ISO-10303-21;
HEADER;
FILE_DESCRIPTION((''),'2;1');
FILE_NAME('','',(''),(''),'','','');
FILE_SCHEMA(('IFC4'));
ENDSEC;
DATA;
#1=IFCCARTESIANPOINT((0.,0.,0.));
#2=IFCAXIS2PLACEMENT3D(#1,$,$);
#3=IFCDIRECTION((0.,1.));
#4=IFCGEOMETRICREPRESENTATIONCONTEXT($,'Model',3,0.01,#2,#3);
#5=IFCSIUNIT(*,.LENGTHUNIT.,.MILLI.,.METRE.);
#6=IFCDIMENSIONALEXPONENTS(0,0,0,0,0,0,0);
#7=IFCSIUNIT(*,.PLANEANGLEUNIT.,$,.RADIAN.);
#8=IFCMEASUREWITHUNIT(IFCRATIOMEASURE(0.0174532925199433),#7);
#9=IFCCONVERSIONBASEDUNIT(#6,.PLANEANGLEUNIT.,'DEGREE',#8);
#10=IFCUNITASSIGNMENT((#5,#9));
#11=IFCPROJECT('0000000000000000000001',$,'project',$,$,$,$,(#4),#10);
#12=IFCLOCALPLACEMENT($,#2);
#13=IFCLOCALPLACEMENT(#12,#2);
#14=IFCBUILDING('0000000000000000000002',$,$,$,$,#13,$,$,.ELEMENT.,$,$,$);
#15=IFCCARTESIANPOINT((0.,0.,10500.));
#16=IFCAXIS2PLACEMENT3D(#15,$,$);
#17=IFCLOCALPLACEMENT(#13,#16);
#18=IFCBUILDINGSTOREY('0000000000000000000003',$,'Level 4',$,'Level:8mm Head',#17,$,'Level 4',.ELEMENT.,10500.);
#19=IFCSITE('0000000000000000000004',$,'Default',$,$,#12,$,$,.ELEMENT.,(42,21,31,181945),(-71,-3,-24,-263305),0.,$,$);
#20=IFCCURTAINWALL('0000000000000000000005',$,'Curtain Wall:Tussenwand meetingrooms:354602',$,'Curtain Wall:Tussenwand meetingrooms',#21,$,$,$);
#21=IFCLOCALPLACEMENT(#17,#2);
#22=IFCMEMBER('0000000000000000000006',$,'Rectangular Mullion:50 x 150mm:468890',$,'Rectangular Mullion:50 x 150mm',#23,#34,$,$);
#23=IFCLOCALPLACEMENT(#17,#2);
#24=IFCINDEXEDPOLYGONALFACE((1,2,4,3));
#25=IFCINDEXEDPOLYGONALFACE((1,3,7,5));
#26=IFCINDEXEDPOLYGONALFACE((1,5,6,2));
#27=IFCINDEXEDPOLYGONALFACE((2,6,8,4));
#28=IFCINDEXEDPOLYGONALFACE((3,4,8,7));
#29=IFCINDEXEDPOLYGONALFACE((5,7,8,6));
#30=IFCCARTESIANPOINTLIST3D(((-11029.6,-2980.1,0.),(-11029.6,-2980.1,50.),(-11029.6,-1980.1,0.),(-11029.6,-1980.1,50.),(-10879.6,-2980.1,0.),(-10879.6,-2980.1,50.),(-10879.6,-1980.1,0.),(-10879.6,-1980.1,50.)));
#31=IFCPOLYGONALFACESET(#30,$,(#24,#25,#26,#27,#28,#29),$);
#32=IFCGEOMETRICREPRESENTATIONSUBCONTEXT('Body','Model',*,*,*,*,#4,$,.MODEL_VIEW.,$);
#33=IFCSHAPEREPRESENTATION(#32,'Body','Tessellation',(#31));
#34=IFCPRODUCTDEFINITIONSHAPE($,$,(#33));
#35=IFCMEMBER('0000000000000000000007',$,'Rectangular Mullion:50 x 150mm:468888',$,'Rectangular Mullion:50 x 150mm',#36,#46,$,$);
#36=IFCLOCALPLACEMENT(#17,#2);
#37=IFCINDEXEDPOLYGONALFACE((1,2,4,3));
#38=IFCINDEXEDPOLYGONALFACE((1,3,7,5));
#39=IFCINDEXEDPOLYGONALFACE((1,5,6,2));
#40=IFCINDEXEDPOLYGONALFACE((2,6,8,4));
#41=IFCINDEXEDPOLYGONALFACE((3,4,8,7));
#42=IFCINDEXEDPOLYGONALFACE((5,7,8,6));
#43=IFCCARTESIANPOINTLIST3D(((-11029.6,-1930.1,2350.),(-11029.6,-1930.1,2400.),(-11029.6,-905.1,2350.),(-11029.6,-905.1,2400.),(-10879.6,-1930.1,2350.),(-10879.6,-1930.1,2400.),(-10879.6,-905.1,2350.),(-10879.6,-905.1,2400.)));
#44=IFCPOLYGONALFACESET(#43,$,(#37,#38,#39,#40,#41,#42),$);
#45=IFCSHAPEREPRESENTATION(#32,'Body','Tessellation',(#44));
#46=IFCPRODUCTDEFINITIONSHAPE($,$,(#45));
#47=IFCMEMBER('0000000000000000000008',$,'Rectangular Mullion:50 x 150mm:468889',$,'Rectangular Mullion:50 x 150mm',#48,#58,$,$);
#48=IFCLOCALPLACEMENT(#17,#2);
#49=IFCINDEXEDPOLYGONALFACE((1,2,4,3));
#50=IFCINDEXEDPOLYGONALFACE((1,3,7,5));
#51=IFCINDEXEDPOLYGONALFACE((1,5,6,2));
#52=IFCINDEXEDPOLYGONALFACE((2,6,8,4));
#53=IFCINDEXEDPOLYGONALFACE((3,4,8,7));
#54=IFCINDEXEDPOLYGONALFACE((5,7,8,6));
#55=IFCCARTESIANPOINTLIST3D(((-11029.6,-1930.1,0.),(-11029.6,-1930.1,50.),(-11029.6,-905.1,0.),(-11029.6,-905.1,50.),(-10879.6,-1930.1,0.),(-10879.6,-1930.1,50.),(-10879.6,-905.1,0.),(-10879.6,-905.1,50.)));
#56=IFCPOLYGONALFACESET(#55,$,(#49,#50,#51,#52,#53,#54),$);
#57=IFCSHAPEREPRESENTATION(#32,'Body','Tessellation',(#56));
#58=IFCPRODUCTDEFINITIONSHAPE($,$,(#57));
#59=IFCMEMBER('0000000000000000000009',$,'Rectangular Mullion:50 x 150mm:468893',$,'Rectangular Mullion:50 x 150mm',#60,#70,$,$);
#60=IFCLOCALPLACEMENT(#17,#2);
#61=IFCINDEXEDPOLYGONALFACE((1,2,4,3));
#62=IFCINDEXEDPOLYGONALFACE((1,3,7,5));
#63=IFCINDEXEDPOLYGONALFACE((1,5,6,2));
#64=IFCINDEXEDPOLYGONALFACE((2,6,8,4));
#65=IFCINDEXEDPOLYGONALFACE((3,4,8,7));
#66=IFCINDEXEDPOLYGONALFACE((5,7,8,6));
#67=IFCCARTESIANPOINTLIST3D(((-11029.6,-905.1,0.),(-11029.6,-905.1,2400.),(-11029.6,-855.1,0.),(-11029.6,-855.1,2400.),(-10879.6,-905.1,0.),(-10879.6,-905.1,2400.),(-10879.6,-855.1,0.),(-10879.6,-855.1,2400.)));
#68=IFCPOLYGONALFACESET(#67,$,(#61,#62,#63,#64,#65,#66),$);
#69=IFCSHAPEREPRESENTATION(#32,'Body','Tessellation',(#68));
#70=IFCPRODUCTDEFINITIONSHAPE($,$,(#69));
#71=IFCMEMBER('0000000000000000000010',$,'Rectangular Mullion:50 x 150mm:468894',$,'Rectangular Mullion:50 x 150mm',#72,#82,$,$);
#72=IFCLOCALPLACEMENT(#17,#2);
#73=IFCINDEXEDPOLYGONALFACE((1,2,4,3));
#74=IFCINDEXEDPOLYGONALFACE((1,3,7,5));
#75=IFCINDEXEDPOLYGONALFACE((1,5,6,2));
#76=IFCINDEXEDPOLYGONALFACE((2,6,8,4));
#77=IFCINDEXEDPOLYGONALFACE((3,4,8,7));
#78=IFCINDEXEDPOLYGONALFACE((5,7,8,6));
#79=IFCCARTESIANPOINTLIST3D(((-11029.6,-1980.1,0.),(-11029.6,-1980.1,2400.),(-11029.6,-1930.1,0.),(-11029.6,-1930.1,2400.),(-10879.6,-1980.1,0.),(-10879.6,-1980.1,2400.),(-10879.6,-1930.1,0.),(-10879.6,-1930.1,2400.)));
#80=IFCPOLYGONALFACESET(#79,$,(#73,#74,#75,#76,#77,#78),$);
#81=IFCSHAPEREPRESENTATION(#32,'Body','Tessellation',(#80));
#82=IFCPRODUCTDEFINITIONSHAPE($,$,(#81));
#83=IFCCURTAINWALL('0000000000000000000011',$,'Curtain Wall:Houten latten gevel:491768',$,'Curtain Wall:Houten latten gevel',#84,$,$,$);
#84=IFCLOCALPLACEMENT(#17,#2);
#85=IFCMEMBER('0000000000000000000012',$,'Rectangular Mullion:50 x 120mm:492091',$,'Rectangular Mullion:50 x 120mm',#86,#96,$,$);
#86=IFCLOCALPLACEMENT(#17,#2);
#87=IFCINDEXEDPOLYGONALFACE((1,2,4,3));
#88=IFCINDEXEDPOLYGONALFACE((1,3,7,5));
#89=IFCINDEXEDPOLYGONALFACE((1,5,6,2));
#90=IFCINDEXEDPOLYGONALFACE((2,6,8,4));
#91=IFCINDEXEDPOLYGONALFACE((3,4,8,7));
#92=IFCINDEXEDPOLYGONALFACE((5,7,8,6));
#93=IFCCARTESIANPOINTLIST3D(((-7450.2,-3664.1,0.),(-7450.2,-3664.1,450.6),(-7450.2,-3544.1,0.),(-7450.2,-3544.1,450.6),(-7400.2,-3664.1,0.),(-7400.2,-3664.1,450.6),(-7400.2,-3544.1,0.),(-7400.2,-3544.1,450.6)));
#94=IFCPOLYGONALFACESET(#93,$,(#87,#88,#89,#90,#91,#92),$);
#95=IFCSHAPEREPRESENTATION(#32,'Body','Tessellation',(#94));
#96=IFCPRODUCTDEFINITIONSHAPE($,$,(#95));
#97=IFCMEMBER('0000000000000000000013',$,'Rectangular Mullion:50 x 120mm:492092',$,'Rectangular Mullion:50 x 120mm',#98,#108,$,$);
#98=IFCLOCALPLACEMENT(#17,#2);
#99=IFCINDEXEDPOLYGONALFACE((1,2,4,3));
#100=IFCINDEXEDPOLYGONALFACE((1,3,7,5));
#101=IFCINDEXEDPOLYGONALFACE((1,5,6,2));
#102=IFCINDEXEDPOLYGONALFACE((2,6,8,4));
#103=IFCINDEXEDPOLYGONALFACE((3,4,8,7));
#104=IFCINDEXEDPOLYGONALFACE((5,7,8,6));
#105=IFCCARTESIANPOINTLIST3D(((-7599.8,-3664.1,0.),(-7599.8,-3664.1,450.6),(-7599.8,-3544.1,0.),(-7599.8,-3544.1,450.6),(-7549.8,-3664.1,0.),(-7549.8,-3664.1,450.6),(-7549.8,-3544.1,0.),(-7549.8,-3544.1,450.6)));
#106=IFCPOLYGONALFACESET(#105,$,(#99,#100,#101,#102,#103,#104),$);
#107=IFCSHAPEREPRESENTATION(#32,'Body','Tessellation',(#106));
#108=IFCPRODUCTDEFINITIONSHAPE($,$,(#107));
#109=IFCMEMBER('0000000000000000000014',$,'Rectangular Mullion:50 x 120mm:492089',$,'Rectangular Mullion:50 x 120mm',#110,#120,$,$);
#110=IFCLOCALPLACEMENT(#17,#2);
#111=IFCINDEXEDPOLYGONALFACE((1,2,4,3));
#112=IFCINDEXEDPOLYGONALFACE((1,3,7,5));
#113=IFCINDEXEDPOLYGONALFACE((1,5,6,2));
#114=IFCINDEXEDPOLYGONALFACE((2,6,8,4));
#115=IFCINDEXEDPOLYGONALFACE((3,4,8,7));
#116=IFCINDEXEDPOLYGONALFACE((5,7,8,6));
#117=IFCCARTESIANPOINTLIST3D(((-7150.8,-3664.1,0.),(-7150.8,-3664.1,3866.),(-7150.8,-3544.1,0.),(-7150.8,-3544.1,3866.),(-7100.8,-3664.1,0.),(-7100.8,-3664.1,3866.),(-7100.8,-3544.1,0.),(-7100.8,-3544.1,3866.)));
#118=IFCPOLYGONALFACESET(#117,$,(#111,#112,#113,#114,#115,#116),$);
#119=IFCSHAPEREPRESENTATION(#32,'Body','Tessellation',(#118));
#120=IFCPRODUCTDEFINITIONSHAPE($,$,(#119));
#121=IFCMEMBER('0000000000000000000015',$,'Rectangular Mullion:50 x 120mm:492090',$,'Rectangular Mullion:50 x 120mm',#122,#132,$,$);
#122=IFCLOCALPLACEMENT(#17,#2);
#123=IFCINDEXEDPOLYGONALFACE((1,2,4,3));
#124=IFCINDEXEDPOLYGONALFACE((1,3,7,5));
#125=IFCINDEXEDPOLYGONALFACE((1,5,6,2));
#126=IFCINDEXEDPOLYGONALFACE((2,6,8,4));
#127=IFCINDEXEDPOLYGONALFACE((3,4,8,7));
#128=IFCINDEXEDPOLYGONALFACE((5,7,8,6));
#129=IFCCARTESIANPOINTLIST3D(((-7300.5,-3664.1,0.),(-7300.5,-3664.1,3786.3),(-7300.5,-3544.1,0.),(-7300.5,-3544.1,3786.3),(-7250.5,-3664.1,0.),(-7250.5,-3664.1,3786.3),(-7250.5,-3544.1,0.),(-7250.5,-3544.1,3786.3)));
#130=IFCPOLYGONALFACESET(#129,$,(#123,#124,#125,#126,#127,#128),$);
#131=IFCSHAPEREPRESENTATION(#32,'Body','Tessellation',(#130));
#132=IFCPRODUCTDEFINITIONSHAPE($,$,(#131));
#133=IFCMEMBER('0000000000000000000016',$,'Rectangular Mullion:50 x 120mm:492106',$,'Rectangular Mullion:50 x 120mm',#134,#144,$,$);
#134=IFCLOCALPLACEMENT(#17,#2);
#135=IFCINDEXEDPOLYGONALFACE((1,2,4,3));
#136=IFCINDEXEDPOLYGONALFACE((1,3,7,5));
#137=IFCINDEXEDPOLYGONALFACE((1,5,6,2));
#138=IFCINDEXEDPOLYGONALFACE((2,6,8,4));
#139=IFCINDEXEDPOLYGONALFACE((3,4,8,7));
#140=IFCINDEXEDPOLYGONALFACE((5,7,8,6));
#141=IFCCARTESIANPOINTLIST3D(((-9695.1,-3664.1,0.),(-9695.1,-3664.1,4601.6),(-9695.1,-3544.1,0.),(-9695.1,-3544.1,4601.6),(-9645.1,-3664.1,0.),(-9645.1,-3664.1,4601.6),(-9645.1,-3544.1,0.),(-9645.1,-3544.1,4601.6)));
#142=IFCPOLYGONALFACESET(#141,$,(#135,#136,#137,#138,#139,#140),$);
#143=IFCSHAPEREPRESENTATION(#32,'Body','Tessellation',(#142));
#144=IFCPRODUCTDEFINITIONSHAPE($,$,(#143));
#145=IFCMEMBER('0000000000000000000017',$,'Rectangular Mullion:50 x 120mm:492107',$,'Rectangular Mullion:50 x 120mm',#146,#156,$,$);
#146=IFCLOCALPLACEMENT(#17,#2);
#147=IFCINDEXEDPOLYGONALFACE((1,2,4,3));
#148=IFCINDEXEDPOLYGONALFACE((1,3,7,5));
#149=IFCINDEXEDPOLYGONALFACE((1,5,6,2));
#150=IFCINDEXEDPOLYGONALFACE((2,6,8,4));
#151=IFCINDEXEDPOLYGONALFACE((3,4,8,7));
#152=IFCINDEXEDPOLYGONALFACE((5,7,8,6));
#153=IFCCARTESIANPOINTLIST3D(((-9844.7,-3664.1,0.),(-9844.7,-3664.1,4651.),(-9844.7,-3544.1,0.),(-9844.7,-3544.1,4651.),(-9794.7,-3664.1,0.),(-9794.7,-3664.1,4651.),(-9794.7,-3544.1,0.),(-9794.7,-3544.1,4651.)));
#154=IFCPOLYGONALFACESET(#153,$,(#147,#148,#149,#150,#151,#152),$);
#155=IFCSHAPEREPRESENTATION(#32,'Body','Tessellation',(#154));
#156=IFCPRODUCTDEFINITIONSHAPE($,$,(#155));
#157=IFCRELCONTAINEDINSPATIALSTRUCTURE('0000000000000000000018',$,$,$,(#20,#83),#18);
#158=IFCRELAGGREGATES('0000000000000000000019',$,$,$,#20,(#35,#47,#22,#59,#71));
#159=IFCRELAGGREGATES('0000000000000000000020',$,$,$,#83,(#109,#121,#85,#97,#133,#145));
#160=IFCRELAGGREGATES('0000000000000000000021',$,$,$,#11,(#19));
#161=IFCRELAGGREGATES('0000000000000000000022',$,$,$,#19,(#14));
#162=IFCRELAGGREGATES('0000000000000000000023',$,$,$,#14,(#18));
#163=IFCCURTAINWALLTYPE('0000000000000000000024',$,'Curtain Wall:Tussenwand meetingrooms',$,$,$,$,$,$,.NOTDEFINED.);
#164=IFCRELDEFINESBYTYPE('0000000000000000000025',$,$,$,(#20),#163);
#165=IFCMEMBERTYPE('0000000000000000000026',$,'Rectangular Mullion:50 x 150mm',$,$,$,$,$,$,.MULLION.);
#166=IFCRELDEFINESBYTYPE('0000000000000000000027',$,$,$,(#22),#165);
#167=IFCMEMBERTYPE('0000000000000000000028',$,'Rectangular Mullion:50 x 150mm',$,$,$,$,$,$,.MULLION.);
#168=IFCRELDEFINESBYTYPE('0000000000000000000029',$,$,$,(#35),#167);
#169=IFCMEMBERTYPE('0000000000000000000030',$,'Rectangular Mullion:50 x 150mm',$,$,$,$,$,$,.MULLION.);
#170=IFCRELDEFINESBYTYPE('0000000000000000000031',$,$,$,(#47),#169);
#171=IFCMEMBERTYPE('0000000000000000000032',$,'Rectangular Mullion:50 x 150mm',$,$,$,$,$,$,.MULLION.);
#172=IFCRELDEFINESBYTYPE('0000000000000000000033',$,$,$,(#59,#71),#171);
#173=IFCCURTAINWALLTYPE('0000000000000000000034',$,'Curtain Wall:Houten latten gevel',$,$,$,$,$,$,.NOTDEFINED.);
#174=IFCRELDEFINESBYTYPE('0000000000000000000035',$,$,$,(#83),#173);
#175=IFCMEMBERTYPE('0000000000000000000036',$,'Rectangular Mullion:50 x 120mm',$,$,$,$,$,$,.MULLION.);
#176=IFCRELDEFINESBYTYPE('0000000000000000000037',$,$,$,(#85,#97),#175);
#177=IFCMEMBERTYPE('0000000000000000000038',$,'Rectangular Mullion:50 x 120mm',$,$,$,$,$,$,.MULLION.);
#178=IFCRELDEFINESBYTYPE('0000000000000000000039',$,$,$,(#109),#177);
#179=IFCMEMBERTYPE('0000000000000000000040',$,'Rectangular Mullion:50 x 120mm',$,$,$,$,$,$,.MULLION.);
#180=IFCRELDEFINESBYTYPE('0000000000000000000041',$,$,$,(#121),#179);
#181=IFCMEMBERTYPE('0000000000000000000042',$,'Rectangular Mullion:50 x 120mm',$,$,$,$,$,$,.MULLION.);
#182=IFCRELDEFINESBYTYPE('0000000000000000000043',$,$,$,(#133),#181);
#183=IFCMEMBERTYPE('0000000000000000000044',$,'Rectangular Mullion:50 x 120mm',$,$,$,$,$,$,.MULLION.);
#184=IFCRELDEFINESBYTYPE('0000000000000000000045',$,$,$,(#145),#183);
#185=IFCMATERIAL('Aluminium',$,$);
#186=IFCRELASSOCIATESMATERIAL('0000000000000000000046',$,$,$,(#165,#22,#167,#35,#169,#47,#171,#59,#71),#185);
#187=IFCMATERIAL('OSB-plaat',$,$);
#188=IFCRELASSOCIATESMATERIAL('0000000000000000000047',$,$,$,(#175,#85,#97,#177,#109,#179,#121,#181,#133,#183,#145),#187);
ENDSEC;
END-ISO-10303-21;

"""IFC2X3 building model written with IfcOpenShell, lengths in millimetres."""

from ifc_helpers import new_model, entity, si_unit, converted_unit, direction, frame, origin, origin_2d_with_axis, place, context, subcontext, project, spatial, rectangle, extrude, source, transform, mapped, material, type_object, type_shapes, element, aggregate, save


model = new_model("IFC2X3")

# Units and contexts
model_context = context("Model", 3, precision=0.01, world=origin(), true_north=direction((0.0, 1.0)))
body_context = subcontext(model_context, "Body", "Model", "MODEL_VIEW")
ifc_project = project(units=[si_unit("LENGTHUNIT", "METRE", prefix="MILLI"), converted_unit("PLANEANGLEUNIT", "DEGREE", entity("IfcRatioMeasure", 0.0174532925199433), si_unit("PLANEANGLEUNIT", "RADIAN"), dimensions=[0, 0, 0, 0, 0, 0, 0])], contexts=[model_context])

# Site, building, storey
site_placement = place(None, frame((0.0, 0.0, 0.0)))
site = spatial("IfcSite", under=ifc_project, at=site_placement, Name="Default", CompositionType="ELEMENT", RefLatitude=(42, 21, 31, 181945), RefLongitude=(-71, -3, -24, -263305), RefElevation=0.0)
building_placement = place(site_placement, origin())
building = spatial("IfcBuilding", under=site, at=building_placement, CompositionType="ELEMENT")
storey_placement = place(building_placement, frame((0.0, 0.0, 10500.0)))
storey = spatial("IfcBuildingStorey", under=building, at=storey_placement, Name="Level 4", ObjectType="Level:8mm Head", LongName="Level 4", CompositionType="ELEMENT", Elevation=10500.0)

# Curtain walls, members
curtain_wall_type_1 = type_object("IfcCurtainWallType", Name="Curtain Wall:Tussenwand meetingrooms", PredefinedType="NOTDEFINED")
curtain_wall_1_placement = place(storey_placement, frame((0.0, 0.0, -10500.0)))
curtain_wall_1 = element("IfcCurtainWall", 1, at=curtain_wall_1_placement, inside=storey, type_object=curtain_wall_type_1, Name="Curtain Wall:Tussenwand meetingrooms:354602", ObjectType="Curtain Wall:Tussenwand meetingrooms")
ifc_material_1 = material(Name="Aluminium")
member_type_1 = type_object("IfcMemberType", Name="Rectangular Mullion:50 x 150mm", PredefinedType="MULLION", material=ifc_material_1)
shared_shape_1 = source(origin(), body_context, "Body", "SweptSolid", [
    extrude(rectangle(XDim=150.0, YDim=50.0, at=origin_2d_with_axis()), frame((-25.0, 0.0, -1000.0), z_axis=(0.0, 0.0, 1.0), x_axis=(0.0, -1.0, 0.0)), (0.0, 0.0, 1.0), 1000.0),
])
type_shapes(member_type_1, [shared_shape_1])
member_1_placement = place(storey_placement, frame((-10954.6, -1980.1, 0.0), z_axis=(0.0, 1.0, 0.0), x_axis=(0.0, 0.0, -1.0)))
member_1 = element("IfcMember", 2, at=member_1_placement, type_object=member_type_1, material=ifc_material_1, Name="Rectangular Mullion:50 x 150mm:468890", ObjectType="Rectangular Mullion:50 x 150mm", context=body_context, shape_type="MappedRepresentation", body=[
    mapped(shared_shape_1, transform((0.0, 0.0, 0.0), scale=1.0)),
])
member_type_2 = type_object("IfcMemberType", Name="Rectangular Mullion:50 x 150mm", PredefinedType="MULLION", material=ifc_material_1)
shared_shape_2 = source(origin(), body_context, "Body", "SweptSolid", [
    extrude(rectangle(XDim=150.0, YDim=50.0, at=origin_2d_with_axis()), frame((-25.0, 0.0, -1025.0), z_axis=(0.0, 0.0, 1.0), x_axis=(0.0, -1.0, 0.0)), (0.0, 0.0, 1.0), 1025.0),
])
type_shapes(member_type_2, [shared_shape_2])
member_2_placement = place(storey_placement, frame((-10954.6, -1930.1, 2400.0), z_axis=(0.0, -1.0, 0.0), x_axis=(0.0, 0.0, 1.0)))
member_2 = element("IfcMember", 3, at=member_2_placement, type_object=member_type_2, material=ifc_material_1, Name="Rectangular Mullion:50 x 150mm:468888", ObjectType="Rectangular Mullion:50 x 150mm", context=body_context, shape_type="MappedRepresentation", body=[
    mapped(shared_shape_2, transform((0.0, 0.0, 0.0), scale=1.0)),
])
member_type_3 = type_object("IfcMemberType", Name="Rectangular Mullion:50 x 150mm", PredefinedType="MULLION", material=ifc_material_1)
shared_shape_3 = source(origin(), body_context, "Body", "SweptSolid", [
    extrude(rectangle(XDim=150.0, YDim=50.0, at=origin_2d_with_axis()), frame((-25.0, 0.0, -1025.0), z_axis=(0.0, 0.0, 1.0), x_axis=(0.0, -1.0, 0.0)), (0.0, 0.0, 1.0), 1025.0),
])
type_shapes(member_type_3, [shared_shape_3])
member_3_placement = place(storey_placement, frame((-10954.6, -905.1, 0.0), z_axis=(0.0, 1.0, 0.0), x_axis=(0.0, 0.0, -1.0)))
member_3 = element("IfcMember", 4, at=member_3_placement, type_object=member_type_3, material=ifc_material_1, Name="Rectangular Mullion:50 x 150mm:468889", ObjectType="Rectangular Mullion:50 x 150mm", context=body_context, shape_type="MappedRepresentation", body=[
    mapped(shared_shape_3, transform((0.0, 0.0, 0.0), scale=1.0)),
])
member_type_4 = type_object("IfcMemberType", Name="Rectangular Mullion:50 x 150mm", PredefinedType="MULLION", material=ifc_material_1)
shared_shape_4 = source(origin(), body_context, "Body", "SweptSolid", [
    extrude(rectangle(XDim=150.0, YDim=50.0, at=origin_2d_with_axis()), frame((0.0, 0.0, -2400.0), z_axis=(0.0, 0.0, 1.0), x_axis=(0.0, -1.0, 0.0)), (0.0, 0.0, 1.0), 2400.0),
])
type_shapes(member_type_4, [shared_shape_4])
member_4_placement = place(storey_placement, frame((-10954.6, -880.1, 0.0), z_axis=(0.0, 0.0, -1.0), x_axis=(0.0, -1.0, 0.0)))
member_4 = element("IfcMember", 5, at=member_4_placement, type_object=member_type_4, material=ifc_material_1, Name="Rectangular Mullion:50 x 150mm:468893", ObjectType="Rectangular Mullion:50 x 150mm", context=body_context, shape_type="MappedRepresentation", body=[
    mapped(shared_shape_4, transform((0.0, 0.0, 0.0), scale=1.0)),
])
member_5_placement = place(storey_placement, frame((-10954.6, -1955.1, 0.0), z_axis=(0.0, 0.0, -1.0), x_axis=(0.0, -1.0, 0.0)))
member_5 = element("IfcMember", 6, at=member_5_placement, type_object=member_type_4, material=ifc_material_1, Name="Rectangular Mullion:50 x 150mm:468894", ObjectType="Rectangular Mullion:50 x 150mm", context=body_context, shape_type="MappedRepresentation", body=[
    mapped(shared_shape_4, transform((0.0, 0.0, 0.0), scale=1.0)),
])
aggregate(curtain_wall_1, [member_2, member_3, member_1, member_4, member_5])
curtain_wall_type_2 = type_object("IfcCurtainWallType", Name="Curtain Wall:Houten latten gevel", PredefinedType="NOTDEFINED")
curtain_wall_2_placement = place(storey_placement, frame((0.0, 0.0, -10500.0)))
curtain_wall_2 = element("IfcCurtainWall", 7, at=curtain_wall_2_placement, inside=storey, type_object=curtain_wall_type_2, Name="Curtain Wall:Houten latten gevel:491768", ObjectType="Curtain Wall:Houten latten gevel")
ifc_material_2 = material(Name="OSB-plaat")
member_type_5 = type_object("IfcMemberType", Name="Rectangular Mullion:50 x 120mm", PredefinedType="MULLION", material=ifc_material_2)
shared_shape_5 = source(origin(), body_context, "Body", "SweptSolid", [
    extrude(rectangle(XDim=120.0, YDim=50.0, at=origin_2d_with_axis()), frame((0.0, 0.0, -450.6), z_axis=(0.0, 0.0, 1.0), x_axis=(0.0, -1.0, 0.0)), (0.0, 0.0, 1.0), 450.6),
])
type_shapes(member_type_5, [shared_shape_5])
placement = place(building_placement, frame((0.0, 0.0, 7500.0)))
member_6_placement = place(placement, frame((-7425.2, -3604.1, 3000.0), z_axis=(0.0, 0.0, -1.0), x_axis=(-1.0, 0.0, 0.0)))
member_6 = element("IfcMember", 8, at=member_6_placement, type_object=member_type_5, material=ifc_material_2, Name="Rectangular Mullion:50 x 120mm:492091", ObjectType="Rectangular Mullion:50 x 120mm", context=body_context, shape_type="MappedRepresentation", body=[
    mapped(shared_shape_5, transform((0.0, 0.0, 0.0), scale=1.0)),
])
member_7_placement = place(placement, frame((-7574.8, -3604.1, 3000.0), z_axis=(0.0, 0.0, -1.0), x_axis=(-1.0, 0.0, 0.0)))
member_7 = element("IfcMember", 9, at=member_7_placement, type_object=member_type_5, material=ifc_material_2, Name="Rectangular Mullion:50 x 120mm:492092", ObjectType="Rectangular Mullion:50 x 120mm", context=body_context, shape_type="MappedRepresentation", body=[
    mapped(shared_shape_5, transform((0.0, 0.0, 0.0), scale=1.0)),
])
member_type_6 = type_object("IfcMemberType", Name="Rectangular Mullion:50 x 120mm", PredefinedType="MULLION", material=ifc_material_2)
shared_shape_6 = source(origin(), body_context, "Body", "SweptSolid", [
    extrude(rectangle(XDim=120.0, YDim=50.0, at=origin_2d_with_axis()), frame((0.0, 0.0, -3866.0), z_axis=(0.0, 0.0, 1.0), x_axis=(0.0, -1.0, 0.0)), (0.0, 0.0, 1.0), 3866.0),
])
type_shapes(member_type_6, [shared_shape_6])
member_8_placement = place(placement, frame((-7125.8, -3604.1, 3000.0), z_axis=(0.0, 0.0, -1.0), x_axis=(-1.0, 0.0, 0.0)))
member_8 = element("IfcMember", 10, at=member_8_placement, type_object=member_type_6, material=ifc_material_2, Name="Rectangular Mullion:50 x 120mm:492089", ObjectType="Rectangular Mullion:50 x 120mm", context=body_context, shape_type="MappedRepresentation", body=[
    mapped(shared_shape_6, transform((0.0, 0.0, 0.0), scale=1.0)),
])
member_type_7 = type_object("IfcMemberType", Name="Rectangular Mullion:50 x 120mm", PredefinedType="MULLION", material=ifc_material_2)
shared_shape_7 = source(origin(), body_context, "Body", "SweptSolid", [
    extrude(rectangle(XDim=120.0, YDim=50.0, at=origin_2d_with_axis()), frame((0.0, 0.0, -3786.3), z_axis=(0.0, 0.0, 1.0), x_axis=(0.0, -1.0, 0.0)), (0.0, 0.0, 1.0), 3786.3),
])
type_shapes(member_type_7, [shared_shape_7])
member_9_placement = place(placement, frame((-7275.5, -3604.1, 3000.0), z_axis=(0.0, 0.0, -1.0), x_axis=(-1.0, 0.0, 0.0)))
member_9 = element("IfcMember", 11, at=member_9_placement, type_object=member_type_7, material=ifc_material_2, Name="Rectangular Mullion:50 x 120mm:492090", ObjectType="Rectangular Mullion:50 x 120mm", context=body_context, shape_type="MappedRepresentation", body=[
    mapped(shared_shape_7, transform((0.0, 0.0, 0.0), scale=1.0)),
])
member_type_8 = type_object("IfcMemberType", Name="Rectangular Mullion:50 x 120mm", PredefinedType="MULLION", material=ifc_material_2)
shared_shape_8 = source(origin(), body_context, "Body", "SweptSolid", [
    extrude(rectangle(XDim=120.0, YDim=50.0, at=origin_2d_with_axis()), frame((0.0, 0.0, -4601.6), z_axis=(0.0, 0.0, 1.0), x_axis=(0.0, -1.0, 0.0)), (0.0, 0.0, 1.0), 4601.6),
])
type_shapes(member_type_8, [shared_shape_8])
member_10_placement = place(placement, frame((-9670.1, -3604.1, 3000.0), z_axis=(0.0, 0.0, -1.0), x_axis=(-1.0, 0.0, 0.0)))
member_10 = element("IfcMember", 12, at=member_10_placement, type_object=member_type_8, material=ifc_material_2, Name="Rectangular Mullion:50 x 120mm:492106", ObjectType="Rectangular Mullion:50 x 120mm", context=body_context, shape_type="MappedRepresentation", body=[
    mapped(shared_shape_8, transform((0.0, 0.0, 0.0), scale=1.0)),
])
member_type_9 = type_object("IfcMemberType", Name="Rectangular Mullion:50 x 120mm", PredefinedType="MULLION", material=ifc_material_2)
shared_shape_9 = source(origin(), body_context, "Body", "SweptSolid", [
    extrude(rectangle(XDim=120.0, YDim=50.0, at=origin_2d_with_axis()), frame((0.0, 0.0, -4651.0), z_axis=(0.0, 0.0, 1.0), x_axis=(0.0, -1.0, 0.0)), (0.0, 0.0, 1.0), 4651.0),
])
type_shapes(member_type_9, [shared_shape_9])
member_11_placement = place(placement, frame((-9819.7, -3604.1, 3000.0), z_axis=(0.0, 0.0, -1.0), x_axis=(-1.0, 0.0, 0.0)))
member_11 = element("IfcMember", 13, at=member_11_placement, type_object=member_type_9, material=ifc_material_2, Name="Rectangular Mullion:50 x 120mm:492107", ObjectType="Rectangular Mullion:50 x 120mm", context=body_context, shape_type="MappedRepresentation", body=[
    mapped(shared_shape_9, transform((0.0, 0.0, 0.0), scale=1.0)),
])
aggregate(curtain_wall_2, [member_8, member_9, member_6, member_7, member_10, member_11])

save(model, "model.ifc")
